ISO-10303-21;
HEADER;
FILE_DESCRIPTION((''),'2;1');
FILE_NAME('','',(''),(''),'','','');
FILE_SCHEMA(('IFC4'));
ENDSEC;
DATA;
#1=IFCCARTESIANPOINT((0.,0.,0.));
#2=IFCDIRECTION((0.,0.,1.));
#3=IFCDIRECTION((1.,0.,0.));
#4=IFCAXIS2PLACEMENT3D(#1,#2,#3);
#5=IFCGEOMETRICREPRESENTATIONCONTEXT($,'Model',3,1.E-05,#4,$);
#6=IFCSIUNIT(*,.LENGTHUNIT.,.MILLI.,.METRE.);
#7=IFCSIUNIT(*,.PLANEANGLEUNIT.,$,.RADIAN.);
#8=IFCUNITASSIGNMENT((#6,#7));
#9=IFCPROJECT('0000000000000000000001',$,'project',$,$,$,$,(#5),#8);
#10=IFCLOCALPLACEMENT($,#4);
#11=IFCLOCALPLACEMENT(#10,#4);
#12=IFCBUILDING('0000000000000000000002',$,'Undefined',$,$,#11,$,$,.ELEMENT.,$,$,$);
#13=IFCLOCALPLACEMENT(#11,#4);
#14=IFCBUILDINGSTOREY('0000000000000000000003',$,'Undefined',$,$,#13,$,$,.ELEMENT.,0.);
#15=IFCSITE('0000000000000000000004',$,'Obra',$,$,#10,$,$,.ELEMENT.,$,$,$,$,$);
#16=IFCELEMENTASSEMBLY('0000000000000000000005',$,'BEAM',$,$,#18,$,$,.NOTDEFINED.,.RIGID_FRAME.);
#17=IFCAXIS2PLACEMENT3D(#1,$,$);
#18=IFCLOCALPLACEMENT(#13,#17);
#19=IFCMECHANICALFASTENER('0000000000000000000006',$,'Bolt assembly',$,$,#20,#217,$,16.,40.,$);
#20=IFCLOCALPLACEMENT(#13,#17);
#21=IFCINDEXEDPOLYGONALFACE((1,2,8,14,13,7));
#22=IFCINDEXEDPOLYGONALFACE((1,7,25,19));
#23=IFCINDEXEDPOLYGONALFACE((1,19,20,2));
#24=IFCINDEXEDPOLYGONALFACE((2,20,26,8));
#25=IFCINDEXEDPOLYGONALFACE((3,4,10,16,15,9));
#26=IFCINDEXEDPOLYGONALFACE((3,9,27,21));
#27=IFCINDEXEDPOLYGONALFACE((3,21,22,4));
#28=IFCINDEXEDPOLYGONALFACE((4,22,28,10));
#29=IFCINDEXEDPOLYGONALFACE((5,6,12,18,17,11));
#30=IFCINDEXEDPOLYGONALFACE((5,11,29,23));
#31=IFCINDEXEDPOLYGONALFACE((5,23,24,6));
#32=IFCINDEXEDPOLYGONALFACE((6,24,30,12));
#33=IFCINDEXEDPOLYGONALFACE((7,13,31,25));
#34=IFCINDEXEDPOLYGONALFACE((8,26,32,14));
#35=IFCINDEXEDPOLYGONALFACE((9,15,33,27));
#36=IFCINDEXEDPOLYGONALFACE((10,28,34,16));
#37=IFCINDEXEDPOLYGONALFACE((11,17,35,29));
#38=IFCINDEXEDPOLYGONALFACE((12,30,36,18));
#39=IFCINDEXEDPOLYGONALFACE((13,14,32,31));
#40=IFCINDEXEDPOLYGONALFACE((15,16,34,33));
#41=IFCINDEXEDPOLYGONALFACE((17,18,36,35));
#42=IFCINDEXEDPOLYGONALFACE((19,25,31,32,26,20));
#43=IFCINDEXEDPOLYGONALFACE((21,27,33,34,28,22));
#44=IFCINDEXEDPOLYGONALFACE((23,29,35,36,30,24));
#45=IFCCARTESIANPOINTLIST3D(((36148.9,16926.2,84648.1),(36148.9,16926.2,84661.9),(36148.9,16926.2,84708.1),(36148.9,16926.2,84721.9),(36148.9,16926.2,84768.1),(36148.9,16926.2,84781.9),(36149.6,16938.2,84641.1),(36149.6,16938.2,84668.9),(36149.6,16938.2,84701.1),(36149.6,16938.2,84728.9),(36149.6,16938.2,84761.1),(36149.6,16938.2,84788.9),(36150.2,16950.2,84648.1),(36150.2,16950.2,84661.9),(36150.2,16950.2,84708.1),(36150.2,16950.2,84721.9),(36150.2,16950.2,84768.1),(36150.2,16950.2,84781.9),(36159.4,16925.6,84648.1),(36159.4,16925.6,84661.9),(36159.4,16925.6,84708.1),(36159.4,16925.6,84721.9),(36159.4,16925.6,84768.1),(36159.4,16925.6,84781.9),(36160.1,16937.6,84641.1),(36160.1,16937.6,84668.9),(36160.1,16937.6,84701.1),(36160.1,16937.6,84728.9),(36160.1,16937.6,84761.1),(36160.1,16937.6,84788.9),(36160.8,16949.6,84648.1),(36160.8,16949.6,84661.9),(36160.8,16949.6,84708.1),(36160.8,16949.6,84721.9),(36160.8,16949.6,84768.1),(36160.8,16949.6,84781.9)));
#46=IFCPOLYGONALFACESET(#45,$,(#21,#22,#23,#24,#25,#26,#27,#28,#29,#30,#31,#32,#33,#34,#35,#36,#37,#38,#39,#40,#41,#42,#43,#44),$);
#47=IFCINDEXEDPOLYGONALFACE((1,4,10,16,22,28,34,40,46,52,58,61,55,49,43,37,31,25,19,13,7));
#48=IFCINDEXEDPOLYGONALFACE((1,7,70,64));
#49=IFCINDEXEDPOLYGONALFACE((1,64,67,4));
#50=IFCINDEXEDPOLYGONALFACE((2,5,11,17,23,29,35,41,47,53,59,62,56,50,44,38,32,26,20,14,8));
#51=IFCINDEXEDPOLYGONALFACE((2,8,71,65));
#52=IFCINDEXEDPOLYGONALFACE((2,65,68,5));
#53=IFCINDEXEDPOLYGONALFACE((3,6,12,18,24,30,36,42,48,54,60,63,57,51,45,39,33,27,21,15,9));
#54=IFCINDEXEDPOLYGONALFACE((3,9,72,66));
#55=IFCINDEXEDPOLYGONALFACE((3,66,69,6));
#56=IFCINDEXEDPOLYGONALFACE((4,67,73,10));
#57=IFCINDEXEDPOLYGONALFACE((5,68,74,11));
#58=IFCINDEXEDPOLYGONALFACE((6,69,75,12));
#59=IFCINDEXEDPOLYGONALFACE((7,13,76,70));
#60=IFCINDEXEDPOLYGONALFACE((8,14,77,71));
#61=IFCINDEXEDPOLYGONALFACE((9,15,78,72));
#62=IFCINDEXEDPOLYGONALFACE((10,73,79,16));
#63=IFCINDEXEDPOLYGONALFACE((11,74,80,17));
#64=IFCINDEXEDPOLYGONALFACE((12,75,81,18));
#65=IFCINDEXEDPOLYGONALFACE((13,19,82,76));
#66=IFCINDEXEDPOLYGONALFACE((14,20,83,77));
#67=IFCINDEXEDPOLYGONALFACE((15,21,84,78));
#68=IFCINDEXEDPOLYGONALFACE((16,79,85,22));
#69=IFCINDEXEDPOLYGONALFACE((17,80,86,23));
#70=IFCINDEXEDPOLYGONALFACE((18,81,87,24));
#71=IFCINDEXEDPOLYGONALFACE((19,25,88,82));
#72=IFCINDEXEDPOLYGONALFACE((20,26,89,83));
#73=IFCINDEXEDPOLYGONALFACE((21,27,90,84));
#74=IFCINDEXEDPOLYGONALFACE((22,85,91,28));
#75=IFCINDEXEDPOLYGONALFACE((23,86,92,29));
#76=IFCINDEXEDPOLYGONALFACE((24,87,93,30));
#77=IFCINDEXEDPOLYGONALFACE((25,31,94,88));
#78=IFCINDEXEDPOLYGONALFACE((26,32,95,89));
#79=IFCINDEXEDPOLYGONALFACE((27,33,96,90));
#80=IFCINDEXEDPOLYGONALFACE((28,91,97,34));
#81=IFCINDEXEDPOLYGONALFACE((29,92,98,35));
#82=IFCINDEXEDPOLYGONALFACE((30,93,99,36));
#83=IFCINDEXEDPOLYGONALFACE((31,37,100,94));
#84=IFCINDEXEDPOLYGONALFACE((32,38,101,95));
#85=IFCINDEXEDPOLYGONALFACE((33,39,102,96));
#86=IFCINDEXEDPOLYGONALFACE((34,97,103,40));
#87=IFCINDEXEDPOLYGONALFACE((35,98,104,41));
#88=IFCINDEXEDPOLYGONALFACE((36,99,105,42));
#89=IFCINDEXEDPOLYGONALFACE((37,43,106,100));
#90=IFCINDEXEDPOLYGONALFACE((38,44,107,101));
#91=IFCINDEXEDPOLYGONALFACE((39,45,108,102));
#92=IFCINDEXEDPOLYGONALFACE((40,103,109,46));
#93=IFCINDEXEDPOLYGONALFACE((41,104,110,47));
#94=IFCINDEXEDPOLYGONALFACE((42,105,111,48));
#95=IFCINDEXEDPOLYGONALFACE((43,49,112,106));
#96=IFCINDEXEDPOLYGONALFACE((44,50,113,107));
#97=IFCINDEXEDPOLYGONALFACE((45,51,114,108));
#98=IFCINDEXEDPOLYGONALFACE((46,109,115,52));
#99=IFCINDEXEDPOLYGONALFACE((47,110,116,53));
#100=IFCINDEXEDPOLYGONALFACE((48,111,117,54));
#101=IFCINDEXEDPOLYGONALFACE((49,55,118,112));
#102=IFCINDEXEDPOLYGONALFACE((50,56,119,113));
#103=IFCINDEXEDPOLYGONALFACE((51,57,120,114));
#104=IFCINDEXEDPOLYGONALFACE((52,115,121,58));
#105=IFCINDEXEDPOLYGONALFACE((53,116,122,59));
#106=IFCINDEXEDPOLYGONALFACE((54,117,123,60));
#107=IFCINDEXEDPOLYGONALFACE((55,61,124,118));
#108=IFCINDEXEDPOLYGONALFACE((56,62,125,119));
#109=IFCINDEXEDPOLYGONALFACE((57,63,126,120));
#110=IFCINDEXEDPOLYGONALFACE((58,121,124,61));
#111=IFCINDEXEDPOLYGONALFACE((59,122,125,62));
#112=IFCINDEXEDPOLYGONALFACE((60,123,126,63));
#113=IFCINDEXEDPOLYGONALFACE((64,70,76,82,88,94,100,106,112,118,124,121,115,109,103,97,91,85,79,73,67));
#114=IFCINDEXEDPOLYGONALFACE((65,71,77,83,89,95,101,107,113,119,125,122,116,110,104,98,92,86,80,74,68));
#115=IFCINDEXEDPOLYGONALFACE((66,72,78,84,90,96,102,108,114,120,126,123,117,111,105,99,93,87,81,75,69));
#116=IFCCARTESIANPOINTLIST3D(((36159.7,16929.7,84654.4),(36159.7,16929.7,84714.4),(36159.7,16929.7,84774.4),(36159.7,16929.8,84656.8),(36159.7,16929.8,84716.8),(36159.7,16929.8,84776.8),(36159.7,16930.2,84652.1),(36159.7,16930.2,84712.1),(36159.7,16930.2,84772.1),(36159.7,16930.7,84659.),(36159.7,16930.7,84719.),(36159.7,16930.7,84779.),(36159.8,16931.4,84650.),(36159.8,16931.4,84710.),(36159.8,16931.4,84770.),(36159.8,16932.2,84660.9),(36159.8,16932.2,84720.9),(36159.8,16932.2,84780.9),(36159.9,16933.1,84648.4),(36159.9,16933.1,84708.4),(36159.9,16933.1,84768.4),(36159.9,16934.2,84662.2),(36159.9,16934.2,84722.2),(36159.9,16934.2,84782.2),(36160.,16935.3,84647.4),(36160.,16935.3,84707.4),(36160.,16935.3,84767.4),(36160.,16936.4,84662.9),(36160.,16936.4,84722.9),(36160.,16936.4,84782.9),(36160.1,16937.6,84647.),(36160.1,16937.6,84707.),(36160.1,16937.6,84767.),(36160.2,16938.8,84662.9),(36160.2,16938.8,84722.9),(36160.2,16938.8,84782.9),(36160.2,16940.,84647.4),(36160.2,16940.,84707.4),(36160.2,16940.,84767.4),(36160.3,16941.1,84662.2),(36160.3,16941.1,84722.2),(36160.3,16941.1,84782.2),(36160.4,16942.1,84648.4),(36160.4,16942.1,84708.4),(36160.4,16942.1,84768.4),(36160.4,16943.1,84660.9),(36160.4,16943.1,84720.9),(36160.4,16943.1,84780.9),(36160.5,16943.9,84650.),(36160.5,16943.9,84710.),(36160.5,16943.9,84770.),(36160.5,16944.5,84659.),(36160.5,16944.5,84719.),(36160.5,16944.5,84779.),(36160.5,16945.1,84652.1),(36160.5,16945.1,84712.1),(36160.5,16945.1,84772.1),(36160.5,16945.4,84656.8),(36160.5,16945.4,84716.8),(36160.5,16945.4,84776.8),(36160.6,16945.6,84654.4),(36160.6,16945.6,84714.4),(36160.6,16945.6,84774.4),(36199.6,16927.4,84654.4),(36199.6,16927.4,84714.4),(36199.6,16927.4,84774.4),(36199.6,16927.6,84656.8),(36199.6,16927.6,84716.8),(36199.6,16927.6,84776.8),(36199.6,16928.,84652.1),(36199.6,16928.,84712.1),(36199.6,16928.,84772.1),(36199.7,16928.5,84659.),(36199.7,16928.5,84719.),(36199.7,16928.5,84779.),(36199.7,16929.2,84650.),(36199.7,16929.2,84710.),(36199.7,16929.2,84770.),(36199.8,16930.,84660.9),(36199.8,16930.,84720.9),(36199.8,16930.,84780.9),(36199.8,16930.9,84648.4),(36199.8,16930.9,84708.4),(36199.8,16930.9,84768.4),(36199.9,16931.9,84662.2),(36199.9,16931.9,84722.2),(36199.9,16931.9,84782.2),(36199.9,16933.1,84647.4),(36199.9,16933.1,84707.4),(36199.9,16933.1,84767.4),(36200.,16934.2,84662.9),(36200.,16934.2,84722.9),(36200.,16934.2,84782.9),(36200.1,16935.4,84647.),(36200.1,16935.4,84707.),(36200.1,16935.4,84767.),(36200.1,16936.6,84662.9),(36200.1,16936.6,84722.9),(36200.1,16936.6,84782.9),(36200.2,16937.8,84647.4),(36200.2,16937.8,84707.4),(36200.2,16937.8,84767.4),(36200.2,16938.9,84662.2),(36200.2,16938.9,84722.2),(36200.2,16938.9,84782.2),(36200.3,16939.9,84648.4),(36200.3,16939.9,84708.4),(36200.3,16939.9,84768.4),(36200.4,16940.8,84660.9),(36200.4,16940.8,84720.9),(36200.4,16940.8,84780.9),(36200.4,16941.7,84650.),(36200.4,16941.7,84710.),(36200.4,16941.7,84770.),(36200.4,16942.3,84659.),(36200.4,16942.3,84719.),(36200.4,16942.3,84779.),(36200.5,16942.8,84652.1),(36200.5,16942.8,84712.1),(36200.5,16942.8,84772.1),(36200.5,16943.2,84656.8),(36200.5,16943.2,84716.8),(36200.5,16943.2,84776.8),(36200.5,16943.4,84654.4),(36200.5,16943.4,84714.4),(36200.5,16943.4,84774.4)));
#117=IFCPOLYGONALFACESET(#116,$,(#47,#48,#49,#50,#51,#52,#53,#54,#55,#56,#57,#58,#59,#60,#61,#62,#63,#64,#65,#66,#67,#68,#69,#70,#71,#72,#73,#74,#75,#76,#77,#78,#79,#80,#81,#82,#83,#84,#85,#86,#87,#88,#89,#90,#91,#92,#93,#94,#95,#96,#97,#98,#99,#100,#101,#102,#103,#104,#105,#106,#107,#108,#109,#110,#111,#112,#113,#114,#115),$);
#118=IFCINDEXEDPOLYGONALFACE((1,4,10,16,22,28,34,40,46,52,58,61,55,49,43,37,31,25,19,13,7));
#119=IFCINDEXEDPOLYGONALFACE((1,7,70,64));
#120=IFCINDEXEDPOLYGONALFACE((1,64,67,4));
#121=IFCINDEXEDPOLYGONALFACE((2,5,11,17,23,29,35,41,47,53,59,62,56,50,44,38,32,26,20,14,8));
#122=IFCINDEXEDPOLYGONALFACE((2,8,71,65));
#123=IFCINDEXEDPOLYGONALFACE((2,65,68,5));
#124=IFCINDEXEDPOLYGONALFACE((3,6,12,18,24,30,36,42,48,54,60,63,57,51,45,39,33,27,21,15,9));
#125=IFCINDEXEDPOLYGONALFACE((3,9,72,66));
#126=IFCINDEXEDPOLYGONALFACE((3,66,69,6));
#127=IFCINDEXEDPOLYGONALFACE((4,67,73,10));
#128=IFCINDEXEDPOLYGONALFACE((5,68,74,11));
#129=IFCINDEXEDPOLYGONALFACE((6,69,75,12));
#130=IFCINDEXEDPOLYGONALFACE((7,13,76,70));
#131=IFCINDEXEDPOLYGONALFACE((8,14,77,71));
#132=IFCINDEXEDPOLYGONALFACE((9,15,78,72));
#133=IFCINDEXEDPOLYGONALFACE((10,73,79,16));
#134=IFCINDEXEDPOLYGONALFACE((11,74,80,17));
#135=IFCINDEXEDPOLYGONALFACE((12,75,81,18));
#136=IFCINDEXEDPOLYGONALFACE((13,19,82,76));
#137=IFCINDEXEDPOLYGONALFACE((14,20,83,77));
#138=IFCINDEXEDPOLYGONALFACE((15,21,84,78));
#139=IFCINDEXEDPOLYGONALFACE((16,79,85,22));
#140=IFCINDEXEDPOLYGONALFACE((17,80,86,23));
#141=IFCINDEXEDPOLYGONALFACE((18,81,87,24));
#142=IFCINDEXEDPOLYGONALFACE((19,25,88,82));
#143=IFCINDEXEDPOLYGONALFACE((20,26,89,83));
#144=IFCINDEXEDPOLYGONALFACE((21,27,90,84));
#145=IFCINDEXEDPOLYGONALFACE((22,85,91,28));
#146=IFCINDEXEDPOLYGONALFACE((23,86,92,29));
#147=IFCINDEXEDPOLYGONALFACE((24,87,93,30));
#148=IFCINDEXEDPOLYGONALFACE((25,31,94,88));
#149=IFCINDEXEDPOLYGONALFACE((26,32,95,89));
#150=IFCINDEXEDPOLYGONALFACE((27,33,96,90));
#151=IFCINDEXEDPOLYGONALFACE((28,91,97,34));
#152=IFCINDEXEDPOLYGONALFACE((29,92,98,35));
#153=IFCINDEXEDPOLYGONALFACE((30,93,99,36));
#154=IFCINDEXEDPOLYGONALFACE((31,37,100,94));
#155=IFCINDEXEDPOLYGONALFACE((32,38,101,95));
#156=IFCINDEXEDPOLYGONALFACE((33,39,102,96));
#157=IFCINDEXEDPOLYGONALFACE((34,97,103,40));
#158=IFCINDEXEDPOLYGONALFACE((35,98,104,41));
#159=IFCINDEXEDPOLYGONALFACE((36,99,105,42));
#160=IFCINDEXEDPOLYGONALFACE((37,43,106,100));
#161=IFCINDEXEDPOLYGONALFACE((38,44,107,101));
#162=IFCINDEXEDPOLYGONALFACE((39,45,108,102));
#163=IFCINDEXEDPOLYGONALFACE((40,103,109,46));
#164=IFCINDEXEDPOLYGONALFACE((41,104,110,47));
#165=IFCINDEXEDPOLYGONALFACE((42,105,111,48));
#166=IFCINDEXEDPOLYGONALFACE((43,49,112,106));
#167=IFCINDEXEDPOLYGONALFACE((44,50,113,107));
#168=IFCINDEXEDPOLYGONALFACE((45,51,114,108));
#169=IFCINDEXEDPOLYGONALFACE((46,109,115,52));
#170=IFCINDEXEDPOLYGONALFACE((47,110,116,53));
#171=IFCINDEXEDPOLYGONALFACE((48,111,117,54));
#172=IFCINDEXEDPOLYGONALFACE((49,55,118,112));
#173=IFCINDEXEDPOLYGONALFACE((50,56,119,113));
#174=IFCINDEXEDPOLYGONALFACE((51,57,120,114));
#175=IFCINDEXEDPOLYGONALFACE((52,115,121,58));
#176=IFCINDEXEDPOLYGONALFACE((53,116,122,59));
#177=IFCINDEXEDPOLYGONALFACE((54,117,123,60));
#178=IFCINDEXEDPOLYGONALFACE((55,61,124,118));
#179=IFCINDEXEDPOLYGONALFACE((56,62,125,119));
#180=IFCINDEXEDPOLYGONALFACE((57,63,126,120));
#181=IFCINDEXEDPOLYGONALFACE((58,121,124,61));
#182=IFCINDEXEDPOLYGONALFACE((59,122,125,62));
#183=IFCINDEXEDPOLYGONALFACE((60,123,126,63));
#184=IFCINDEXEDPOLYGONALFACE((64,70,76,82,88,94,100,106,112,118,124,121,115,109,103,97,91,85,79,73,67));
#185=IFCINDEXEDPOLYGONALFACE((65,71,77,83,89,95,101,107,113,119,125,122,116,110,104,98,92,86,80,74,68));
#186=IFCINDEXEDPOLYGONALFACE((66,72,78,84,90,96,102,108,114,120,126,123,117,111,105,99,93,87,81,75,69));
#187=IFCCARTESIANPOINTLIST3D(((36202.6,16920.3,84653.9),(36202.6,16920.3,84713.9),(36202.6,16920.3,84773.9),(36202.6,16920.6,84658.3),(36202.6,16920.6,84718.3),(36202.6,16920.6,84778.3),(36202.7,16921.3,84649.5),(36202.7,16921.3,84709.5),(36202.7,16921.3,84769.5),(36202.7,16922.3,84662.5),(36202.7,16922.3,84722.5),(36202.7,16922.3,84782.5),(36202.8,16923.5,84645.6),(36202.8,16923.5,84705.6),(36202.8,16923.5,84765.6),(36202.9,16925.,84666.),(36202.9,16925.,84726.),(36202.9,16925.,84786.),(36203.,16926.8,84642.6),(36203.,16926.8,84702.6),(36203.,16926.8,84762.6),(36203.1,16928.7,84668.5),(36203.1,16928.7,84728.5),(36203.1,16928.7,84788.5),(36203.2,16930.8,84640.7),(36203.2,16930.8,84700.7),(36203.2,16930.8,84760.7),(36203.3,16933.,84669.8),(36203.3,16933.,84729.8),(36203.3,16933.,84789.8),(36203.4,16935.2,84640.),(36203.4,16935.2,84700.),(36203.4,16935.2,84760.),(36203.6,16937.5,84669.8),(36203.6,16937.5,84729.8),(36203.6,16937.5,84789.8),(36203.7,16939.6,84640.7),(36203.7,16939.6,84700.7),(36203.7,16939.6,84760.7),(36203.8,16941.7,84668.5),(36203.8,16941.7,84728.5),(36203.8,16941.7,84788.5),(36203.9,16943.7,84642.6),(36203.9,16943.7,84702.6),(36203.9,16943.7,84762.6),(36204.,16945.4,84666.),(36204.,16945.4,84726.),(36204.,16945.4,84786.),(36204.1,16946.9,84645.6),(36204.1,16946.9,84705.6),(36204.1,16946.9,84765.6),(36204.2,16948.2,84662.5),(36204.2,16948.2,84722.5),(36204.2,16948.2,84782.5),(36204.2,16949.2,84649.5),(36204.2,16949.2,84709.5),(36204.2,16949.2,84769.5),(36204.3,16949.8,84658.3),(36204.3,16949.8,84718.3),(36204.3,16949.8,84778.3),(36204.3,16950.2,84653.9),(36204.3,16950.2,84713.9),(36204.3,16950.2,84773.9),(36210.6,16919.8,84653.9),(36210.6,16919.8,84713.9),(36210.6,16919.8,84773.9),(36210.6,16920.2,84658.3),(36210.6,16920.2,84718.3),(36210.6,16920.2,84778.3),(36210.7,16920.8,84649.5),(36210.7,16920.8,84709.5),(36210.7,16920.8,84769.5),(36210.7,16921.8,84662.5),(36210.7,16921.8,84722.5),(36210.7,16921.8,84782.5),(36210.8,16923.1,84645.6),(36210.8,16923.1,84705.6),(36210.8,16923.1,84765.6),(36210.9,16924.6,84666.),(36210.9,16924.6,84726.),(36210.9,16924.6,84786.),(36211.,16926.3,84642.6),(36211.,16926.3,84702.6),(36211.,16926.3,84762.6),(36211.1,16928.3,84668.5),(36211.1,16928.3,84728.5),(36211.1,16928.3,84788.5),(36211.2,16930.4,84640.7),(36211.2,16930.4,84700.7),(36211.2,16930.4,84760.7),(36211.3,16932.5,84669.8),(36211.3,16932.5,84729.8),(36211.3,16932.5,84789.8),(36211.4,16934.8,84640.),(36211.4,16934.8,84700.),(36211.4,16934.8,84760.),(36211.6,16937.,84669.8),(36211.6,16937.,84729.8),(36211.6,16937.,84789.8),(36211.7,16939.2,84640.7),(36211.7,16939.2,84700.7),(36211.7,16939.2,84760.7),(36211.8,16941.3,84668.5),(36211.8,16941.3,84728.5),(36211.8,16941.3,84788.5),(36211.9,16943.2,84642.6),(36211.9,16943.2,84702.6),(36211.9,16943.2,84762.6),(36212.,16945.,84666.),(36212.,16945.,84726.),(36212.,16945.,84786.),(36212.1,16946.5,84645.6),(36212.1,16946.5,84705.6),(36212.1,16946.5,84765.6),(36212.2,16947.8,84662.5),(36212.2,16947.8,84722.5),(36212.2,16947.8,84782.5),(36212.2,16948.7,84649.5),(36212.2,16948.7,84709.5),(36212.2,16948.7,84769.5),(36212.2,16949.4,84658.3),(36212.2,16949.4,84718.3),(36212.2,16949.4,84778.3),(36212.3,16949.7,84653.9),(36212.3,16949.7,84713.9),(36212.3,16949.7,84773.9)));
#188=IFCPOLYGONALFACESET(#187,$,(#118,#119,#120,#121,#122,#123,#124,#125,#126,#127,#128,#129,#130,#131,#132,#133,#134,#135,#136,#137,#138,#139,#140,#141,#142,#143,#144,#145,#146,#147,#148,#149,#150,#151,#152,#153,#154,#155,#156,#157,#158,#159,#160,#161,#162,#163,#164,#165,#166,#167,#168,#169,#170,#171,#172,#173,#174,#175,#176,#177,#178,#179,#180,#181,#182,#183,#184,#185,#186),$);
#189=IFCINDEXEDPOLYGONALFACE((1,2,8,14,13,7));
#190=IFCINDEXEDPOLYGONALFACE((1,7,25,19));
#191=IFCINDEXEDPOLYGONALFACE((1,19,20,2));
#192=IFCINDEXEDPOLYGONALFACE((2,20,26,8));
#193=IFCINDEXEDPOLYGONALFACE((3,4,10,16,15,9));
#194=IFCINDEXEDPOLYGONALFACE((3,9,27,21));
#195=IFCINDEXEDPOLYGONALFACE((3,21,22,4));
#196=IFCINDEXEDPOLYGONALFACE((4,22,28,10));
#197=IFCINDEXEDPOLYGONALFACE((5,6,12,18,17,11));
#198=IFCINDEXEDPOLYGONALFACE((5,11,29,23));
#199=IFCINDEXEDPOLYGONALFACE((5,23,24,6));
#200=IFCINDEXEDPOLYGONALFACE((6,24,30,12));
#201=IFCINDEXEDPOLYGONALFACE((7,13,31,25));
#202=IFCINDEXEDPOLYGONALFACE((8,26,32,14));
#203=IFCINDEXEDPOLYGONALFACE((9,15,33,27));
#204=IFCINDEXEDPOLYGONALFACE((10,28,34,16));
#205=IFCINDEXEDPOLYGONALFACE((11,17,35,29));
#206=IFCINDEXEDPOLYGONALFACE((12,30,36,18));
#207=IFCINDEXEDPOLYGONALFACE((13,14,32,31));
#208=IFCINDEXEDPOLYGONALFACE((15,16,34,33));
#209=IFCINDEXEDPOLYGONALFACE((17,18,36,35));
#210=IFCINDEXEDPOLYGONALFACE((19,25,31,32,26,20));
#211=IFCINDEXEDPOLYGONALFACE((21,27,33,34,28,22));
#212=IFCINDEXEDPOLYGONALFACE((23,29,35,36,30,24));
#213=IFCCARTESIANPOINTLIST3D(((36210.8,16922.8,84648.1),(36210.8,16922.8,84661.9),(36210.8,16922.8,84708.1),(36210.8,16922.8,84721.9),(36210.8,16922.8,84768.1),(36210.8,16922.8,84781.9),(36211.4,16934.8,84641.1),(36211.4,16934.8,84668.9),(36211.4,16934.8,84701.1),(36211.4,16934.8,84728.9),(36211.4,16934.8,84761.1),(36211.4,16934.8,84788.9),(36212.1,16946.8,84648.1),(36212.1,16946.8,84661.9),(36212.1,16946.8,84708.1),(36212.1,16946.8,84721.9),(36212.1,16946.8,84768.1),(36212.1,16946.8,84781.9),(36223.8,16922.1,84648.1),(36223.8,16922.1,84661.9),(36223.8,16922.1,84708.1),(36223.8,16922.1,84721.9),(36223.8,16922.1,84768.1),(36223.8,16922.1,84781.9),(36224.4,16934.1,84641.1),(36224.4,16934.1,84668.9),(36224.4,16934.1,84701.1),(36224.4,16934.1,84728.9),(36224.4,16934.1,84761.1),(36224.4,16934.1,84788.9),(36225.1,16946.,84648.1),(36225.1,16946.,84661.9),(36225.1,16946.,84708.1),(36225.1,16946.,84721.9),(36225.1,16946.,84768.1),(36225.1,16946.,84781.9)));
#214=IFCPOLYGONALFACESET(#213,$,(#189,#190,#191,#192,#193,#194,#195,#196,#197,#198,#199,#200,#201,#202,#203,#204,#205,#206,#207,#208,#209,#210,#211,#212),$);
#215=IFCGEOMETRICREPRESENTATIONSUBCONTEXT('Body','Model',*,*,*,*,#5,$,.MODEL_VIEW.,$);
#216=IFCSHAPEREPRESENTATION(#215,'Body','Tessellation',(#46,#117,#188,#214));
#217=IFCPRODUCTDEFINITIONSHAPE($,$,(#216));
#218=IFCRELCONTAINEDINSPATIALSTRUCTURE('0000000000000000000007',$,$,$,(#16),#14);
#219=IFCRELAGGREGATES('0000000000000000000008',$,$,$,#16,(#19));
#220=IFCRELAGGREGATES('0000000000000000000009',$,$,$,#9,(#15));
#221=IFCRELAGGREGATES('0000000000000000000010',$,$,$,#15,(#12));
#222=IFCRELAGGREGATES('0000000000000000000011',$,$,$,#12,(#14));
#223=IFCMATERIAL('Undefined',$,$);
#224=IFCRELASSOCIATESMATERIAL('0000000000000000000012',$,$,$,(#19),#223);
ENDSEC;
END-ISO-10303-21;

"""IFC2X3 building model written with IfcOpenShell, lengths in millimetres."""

from ifc_helpers import new_model, si_unit, frame, origin_with_axes, origin_2d_with_axis, place, context, subcontext, project, spatial, polyline, circle, outline, extrude, source, transform, mapped, material, element, aggregate, save


model = new_model("IFC2X3")

# Units and contexts
model_context = context("Model", 3, precision=1e-05, world=origin_with_axes())
body_context = subcontext(model_context, "Body", "Model", "MODEL_VIEW")
ifc_project = project(units=[si_unit("LENGTHUNIT", "METRE", prefix="MILLI"), si_unit("PLANEANGLEUNIT", "RADIAN")], contexts=[model_context])

# Site, building, storey
site_placement = place(None, origin_with_axes())
site = spatial("IfcSite", under=ifc_project, at=site_placement, Name="Obra", CompositionType="ELEMENT")
building_placement = place(site_placement, origin_with_axes())
building = spatial("IfcBuilding", under=site, at=building_placement, Name="Undefined", CompositionType="ELEMENT")
storey_placement = place(building_placement, origin_with_axes())
storey = spatial("IfcBuildingStorey", under=building, at=storey_placement, Name="Undefined", CompositionType="ELEMENT", Elevation=0.0)

# Element assembly, mechanical fastener
ifc_material_1 = material(Name="Undefined")
shared_shape_1 = source(origin_with_axes(), body_context, "Body", "SweptSolid", [
    extrude(outline(polyline([(13.9, 0.0), (6.9, 12.0), (-6.9, 12.0), (-13.9, 0.0), (-6.9, -12.0), (6.9, -12.0), (13.9, 0.0)])), frame((0.0, -19.7, 0.0), z_axis=(0.0, 1.0, 0.0), x_axis=(1.0, 0.0, 0.0)), (0.0, 0.0, 1.0), 10.6),
    extrude(circle(Radius=8.0, at=origin_2d_with_axis()), frame((0.0, -9.1, 0.0), z_axis=(0.0, 1.0, 0.0), x_axis=(1.0, 0.0, 0.0)), (0.0, 0.0, 1.0), 40.0),
    extrude(circle(Radius=15.0, at=origin_2d_with_axis()), frame((0.0, 34.3, 0.0), z_axis=(0.0, 1.0, 0.0), x_axis=(1.0, 0.0, 0.0)), (0.0, 0.0, 1.0), 8.0),
    extrude(outline(polyline([(13.9, 0.0), (6.9, 12.0), (-6.9, 12.0), (-13.9, 0.0), (-6.9, -12.0), (6.9, -12.0), (13.9, 0.0)])), frame((0.0, 42.3, 0.0), z_axis=(0.0, 1.0, 0.0), x_axis=(1.0, 0.0, 0.0)), (0.0, 0.0, 1.0), 13.0),
])
assembly_1_placement = place(storey_placement, origin_with_axes())
assembly_1 = element("IfcElementAssembly", 1, at=assembly_1_placement, inside=storey, Name="BEAM", AssemblyPlace="NOTDEFINED", PredefinedType="RIGID_FRAME")
mechanical_fastener_1_placement = place(assembly_1_placement, frame((36172.0, 16987.0, 84835.0), z_axis=(-0.055268, -0.998472, 0.0), x_axis=(0.0, 0.0, -1.0)))
mechanical_fastener_1 = element("IfcMechanicalFastener", 2, at=mechanical_fastener_1_placement, material=ifc_material_1, Name="Bolt assembly", NominalDiameter=16.0, NominalLength=40.0, context=body_context, shape_type="MappedRepresentation", body=[
    mapped(shared_shape_1, transform((60.0, 0.0, 50.0))),
    mapped(shared_shape_1, transform((120.0, 0.0, 50.0))),
    mapped(shared_shape_1, transform((180.0, 0.0, 50.0))),
])
aggregate(assembly_1, [mechanical_fastener_1])

save(model, "model.ifc")
